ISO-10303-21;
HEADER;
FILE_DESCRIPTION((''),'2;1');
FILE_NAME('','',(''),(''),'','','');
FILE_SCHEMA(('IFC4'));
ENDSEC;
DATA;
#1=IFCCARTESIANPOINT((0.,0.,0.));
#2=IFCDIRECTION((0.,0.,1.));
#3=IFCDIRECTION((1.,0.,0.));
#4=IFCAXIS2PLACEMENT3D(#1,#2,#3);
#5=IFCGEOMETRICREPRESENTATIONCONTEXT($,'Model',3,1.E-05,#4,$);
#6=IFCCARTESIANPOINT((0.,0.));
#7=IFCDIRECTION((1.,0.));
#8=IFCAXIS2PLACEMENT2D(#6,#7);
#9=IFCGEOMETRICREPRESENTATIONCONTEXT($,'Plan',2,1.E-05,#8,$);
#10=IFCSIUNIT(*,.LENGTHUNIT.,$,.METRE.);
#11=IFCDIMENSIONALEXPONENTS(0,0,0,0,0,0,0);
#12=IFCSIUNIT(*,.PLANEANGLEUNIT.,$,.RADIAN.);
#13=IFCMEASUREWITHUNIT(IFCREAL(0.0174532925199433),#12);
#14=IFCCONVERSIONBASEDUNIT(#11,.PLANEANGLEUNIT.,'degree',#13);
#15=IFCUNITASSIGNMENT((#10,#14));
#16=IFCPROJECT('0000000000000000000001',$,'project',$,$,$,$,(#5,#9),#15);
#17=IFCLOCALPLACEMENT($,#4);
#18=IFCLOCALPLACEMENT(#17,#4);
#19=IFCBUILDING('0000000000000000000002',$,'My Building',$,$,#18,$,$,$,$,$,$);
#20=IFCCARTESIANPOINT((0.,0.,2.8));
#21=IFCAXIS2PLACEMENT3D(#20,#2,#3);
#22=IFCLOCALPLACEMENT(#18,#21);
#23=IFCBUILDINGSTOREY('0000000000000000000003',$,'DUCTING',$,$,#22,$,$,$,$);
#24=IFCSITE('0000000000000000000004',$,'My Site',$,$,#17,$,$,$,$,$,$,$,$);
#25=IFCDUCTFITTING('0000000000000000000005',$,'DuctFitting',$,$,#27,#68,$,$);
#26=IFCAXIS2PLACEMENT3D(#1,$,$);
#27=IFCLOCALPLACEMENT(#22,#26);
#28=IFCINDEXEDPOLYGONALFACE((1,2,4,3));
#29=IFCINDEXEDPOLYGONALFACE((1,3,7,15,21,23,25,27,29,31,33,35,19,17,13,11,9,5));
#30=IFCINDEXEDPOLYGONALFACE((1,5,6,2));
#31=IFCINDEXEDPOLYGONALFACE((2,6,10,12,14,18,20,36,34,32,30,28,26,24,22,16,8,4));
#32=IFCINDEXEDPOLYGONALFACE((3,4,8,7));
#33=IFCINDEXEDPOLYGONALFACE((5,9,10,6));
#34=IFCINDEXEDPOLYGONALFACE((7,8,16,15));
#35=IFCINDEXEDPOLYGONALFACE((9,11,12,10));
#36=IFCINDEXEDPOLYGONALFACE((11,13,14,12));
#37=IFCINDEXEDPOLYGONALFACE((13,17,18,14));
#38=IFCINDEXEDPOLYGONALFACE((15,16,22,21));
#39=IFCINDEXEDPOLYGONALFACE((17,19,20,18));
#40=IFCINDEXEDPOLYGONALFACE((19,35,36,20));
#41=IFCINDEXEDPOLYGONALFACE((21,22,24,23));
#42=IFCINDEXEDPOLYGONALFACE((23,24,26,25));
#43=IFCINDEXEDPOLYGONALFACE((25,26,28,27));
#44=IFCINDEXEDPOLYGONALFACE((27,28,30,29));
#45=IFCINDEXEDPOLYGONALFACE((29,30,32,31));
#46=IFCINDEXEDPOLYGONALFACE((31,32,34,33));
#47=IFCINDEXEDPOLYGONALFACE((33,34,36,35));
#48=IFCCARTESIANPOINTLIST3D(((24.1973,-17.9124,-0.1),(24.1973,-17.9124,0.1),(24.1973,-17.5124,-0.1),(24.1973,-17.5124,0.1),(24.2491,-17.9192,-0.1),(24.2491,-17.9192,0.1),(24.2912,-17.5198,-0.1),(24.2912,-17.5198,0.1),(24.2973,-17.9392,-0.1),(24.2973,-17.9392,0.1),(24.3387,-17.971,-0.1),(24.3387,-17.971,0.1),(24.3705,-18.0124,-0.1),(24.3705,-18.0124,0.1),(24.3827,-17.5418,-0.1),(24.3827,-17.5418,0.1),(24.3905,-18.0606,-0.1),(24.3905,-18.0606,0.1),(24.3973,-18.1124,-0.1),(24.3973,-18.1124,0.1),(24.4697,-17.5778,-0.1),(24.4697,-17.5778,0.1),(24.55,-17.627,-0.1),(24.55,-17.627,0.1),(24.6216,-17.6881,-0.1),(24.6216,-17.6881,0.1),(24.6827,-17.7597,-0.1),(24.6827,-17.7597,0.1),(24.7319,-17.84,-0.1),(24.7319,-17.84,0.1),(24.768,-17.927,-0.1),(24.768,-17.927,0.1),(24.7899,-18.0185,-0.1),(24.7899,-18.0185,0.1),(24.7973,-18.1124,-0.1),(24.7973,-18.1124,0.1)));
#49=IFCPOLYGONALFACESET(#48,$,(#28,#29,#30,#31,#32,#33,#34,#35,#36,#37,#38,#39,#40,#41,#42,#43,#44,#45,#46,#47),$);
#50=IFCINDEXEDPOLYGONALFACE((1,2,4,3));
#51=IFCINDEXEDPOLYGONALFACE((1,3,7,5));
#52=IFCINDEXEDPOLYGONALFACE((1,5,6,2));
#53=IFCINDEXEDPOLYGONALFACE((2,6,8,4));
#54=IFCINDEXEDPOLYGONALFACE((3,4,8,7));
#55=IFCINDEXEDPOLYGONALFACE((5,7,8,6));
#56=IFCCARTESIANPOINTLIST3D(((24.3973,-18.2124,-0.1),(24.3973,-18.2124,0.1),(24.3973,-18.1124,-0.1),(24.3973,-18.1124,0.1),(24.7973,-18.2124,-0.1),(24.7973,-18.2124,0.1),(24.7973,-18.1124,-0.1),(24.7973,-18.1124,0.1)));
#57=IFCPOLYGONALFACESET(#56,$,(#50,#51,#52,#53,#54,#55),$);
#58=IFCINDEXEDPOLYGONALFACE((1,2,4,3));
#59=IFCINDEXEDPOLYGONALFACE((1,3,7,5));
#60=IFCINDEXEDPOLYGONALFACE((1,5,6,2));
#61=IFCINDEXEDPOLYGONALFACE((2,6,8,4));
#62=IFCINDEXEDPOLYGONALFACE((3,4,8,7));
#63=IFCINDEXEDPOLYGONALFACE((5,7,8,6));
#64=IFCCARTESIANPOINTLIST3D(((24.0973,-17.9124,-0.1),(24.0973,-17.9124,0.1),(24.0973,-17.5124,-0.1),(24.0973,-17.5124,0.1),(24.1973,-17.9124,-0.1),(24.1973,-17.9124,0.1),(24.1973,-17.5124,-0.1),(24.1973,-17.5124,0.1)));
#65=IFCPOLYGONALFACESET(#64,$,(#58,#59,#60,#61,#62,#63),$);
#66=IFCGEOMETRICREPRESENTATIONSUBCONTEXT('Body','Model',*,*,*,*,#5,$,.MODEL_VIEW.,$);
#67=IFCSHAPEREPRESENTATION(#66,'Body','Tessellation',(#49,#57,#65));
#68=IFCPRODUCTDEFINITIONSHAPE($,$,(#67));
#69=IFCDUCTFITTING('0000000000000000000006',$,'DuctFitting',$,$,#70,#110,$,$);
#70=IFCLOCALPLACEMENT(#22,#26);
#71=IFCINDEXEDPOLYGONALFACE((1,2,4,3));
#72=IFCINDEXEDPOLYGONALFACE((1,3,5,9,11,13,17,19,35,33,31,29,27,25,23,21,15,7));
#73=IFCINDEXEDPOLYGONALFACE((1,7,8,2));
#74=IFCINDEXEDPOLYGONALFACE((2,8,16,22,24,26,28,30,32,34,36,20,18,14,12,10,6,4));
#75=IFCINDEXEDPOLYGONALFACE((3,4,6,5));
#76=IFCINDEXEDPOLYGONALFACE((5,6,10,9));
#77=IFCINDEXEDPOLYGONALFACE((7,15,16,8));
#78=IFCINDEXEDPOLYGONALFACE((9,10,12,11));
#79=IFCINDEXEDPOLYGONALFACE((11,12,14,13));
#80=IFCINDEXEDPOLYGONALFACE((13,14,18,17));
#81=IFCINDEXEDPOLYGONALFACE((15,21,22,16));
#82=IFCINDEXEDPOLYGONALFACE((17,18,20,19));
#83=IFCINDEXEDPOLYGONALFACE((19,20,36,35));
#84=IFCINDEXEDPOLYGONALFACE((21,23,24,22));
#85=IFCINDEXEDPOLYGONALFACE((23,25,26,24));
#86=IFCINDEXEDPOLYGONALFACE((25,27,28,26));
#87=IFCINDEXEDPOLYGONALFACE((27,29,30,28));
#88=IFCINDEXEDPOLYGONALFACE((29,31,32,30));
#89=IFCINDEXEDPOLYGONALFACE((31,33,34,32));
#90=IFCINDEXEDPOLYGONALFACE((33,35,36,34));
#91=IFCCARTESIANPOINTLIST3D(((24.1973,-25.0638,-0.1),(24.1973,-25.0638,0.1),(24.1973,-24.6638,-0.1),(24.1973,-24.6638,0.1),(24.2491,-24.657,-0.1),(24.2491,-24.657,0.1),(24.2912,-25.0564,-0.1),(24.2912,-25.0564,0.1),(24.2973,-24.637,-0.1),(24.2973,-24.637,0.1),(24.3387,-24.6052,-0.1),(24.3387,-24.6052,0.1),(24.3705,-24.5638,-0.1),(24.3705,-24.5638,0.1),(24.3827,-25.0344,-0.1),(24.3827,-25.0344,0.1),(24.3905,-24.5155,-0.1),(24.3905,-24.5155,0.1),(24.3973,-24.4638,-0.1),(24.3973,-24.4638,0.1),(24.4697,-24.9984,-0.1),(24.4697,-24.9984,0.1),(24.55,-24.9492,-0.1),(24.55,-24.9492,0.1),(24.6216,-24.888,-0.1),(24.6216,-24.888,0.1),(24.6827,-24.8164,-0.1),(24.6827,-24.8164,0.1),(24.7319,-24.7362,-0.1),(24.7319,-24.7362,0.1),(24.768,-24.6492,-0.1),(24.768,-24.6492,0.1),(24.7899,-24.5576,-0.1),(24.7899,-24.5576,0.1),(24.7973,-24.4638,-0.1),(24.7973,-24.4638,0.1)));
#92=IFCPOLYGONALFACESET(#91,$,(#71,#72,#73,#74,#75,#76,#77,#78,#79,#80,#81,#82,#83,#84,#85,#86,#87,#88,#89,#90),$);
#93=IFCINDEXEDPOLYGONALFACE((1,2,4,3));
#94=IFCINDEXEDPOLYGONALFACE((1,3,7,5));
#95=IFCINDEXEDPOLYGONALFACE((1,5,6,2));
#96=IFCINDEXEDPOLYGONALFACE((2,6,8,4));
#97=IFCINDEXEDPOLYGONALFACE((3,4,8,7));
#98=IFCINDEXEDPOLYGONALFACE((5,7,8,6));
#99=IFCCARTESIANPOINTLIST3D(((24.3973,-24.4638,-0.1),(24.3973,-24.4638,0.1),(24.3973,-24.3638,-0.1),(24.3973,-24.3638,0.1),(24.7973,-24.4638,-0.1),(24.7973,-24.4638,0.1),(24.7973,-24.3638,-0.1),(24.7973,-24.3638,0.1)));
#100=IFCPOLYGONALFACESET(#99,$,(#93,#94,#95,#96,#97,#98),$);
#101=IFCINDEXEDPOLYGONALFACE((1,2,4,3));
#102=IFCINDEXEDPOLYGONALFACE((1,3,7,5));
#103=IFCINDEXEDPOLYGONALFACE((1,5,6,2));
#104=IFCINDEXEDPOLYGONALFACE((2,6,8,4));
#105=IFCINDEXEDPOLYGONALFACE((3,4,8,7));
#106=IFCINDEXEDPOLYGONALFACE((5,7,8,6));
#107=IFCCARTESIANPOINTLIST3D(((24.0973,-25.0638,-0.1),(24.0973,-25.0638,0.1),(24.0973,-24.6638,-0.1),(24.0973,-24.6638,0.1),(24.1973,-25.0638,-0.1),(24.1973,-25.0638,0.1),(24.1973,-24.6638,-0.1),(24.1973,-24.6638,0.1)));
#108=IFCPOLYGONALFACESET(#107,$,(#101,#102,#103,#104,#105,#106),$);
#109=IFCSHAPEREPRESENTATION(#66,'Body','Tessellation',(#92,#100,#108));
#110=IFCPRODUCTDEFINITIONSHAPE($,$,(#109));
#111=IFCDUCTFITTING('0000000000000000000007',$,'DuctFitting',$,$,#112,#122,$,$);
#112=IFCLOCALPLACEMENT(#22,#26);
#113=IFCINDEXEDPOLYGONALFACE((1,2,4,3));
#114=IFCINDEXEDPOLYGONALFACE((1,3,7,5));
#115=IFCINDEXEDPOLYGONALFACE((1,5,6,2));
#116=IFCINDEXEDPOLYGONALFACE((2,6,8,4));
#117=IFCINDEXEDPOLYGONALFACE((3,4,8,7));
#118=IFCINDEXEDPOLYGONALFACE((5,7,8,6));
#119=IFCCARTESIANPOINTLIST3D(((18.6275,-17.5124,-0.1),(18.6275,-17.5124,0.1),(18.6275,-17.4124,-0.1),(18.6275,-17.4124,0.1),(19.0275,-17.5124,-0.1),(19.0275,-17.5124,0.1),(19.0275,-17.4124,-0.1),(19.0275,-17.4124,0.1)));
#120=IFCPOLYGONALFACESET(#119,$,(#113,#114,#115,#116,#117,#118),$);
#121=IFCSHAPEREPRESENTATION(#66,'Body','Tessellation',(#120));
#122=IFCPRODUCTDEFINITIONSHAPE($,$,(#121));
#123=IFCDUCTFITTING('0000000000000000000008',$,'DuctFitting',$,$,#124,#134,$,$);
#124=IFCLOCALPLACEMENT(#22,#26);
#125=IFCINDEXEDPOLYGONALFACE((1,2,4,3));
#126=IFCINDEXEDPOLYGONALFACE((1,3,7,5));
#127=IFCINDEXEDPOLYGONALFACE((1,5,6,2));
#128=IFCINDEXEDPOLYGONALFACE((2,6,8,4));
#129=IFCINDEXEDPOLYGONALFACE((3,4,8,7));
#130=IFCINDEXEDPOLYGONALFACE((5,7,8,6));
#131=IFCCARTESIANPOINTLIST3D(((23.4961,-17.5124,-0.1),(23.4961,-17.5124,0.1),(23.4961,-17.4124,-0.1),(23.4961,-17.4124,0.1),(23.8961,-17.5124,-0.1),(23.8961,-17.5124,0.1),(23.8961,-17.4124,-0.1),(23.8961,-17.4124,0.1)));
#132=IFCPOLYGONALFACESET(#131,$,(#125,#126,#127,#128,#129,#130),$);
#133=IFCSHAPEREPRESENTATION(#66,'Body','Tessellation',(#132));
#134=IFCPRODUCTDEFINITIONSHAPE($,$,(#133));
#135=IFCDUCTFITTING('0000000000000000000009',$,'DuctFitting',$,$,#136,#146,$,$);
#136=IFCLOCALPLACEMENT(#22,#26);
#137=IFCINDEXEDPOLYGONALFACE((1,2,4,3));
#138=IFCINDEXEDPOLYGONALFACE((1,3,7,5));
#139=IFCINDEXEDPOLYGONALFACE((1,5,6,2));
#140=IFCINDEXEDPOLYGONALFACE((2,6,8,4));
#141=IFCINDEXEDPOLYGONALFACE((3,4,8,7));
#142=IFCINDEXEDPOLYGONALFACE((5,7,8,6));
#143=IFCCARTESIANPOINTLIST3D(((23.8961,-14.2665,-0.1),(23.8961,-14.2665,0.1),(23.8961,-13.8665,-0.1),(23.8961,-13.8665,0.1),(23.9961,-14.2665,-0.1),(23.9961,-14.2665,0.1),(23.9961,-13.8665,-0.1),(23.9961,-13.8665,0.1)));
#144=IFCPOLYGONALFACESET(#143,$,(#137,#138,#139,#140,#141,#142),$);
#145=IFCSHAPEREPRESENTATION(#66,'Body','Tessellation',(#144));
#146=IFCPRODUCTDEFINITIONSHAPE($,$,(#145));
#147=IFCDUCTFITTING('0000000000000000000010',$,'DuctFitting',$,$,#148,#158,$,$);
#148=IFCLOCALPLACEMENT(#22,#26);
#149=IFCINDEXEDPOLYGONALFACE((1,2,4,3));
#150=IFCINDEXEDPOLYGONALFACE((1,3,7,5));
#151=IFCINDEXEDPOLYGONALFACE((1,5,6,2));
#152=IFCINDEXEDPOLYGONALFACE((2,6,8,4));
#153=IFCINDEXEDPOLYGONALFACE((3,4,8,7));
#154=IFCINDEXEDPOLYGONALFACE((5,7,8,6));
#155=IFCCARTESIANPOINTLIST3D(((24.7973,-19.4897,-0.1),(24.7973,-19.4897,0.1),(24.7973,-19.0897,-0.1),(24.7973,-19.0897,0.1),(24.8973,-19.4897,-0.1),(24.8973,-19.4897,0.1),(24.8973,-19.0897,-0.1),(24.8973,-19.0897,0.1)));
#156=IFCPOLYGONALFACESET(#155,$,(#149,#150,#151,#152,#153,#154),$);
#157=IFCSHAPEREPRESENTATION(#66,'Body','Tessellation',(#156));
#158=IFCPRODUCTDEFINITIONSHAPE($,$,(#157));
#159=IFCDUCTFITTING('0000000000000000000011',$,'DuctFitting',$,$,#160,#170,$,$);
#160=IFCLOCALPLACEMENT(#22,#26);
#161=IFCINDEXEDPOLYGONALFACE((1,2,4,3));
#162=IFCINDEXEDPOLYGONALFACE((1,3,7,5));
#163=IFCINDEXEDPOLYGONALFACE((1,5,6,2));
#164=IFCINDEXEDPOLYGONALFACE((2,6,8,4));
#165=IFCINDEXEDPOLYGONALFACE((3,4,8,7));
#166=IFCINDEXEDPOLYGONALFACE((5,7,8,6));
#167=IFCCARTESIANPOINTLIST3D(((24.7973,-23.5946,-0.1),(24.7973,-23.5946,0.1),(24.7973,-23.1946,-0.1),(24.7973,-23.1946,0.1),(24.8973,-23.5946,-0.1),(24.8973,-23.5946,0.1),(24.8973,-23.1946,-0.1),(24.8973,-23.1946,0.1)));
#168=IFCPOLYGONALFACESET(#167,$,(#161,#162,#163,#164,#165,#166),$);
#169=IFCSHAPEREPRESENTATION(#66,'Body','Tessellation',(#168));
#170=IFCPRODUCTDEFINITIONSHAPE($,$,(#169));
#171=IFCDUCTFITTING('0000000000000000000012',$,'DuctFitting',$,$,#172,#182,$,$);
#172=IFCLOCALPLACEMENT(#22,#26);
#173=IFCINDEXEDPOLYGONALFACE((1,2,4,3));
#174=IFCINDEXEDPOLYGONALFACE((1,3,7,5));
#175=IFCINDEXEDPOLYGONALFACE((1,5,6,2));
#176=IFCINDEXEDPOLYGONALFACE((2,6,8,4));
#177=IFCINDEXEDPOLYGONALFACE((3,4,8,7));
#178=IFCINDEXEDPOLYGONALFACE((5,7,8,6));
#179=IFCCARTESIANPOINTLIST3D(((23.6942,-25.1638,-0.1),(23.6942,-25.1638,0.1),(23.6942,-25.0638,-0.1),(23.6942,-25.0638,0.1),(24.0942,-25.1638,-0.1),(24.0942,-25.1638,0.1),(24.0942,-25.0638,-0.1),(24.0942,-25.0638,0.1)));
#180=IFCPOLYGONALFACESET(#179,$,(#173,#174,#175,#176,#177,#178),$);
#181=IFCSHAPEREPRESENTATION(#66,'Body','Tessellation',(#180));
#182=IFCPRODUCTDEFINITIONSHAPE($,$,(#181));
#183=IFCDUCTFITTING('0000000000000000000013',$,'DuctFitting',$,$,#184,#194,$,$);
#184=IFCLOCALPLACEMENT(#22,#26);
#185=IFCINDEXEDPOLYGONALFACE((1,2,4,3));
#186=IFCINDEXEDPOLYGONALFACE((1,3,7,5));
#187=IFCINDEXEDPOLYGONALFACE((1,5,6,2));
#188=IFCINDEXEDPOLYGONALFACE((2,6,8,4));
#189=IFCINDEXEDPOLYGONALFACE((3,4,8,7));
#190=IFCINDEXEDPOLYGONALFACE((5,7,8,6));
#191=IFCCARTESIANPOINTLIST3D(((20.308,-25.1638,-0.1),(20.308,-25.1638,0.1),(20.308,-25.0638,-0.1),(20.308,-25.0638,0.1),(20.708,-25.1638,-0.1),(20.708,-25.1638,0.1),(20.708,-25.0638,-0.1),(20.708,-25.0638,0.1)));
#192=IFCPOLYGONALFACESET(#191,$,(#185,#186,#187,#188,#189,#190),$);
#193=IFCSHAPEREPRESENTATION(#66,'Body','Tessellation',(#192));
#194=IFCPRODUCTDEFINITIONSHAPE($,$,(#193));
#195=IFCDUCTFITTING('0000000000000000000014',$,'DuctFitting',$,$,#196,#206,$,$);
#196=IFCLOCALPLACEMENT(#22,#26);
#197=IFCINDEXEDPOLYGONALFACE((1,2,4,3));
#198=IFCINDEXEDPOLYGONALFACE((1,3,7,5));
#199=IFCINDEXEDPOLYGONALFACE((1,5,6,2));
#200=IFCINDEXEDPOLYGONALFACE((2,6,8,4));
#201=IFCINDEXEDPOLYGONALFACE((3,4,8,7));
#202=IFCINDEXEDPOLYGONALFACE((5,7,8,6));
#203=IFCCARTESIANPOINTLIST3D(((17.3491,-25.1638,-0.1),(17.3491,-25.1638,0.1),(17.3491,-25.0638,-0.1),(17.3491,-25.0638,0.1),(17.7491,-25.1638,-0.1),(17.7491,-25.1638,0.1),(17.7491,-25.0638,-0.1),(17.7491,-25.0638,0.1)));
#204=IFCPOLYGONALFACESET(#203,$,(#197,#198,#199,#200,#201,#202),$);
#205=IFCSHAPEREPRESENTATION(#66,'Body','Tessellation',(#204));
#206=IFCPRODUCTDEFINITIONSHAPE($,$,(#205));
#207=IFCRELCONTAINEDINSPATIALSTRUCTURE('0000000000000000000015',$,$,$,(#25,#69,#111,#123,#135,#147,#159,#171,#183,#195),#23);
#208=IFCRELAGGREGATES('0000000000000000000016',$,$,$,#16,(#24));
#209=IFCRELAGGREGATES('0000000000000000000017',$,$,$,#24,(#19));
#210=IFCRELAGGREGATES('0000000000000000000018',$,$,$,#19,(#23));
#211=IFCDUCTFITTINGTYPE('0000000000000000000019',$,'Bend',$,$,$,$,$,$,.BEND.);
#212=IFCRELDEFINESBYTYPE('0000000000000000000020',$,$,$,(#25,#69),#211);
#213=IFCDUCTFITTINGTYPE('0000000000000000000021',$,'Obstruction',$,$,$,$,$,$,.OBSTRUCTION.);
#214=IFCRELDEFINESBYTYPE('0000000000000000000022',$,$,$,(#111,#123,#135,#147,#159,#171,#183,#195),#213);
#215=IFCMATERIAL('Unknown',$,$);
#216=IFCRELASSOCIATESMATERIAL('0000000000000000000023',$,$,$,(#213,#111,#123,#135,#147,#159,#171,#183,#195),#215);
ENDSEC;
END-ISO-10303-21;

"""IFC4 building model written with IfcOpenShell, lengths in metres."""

from ifc_helpers import new_model, entity, si_unit, converted_unit, frame, origin_with_axes, origin_2d_with_axis, place, context, subcontext, project, spatial, line, arc, indexed_curve, rectangle, outline, extrude, source, transform, mapped, material, material_profile, profile_set, profile_usage, type_object, type_shapes, element, save


model = new_model("IFC4")

# Units and contexts
model_context = context("Model", 3, precision=1e-05, world=origin_with_axes())
plan_context = context("Plan", 2, precision=1e-05, world=origin_2d_with_axis())
body_context = subcontext(model_context, "Body", "Model", "MODEL_VIEW")
ifc_project = project(units=[si_unit("LENGTHUNIT", "METRE"), converted_unit("PLANEANGLEUNIT", "degree", entity("IfcReal", 0.0174532925199433), si_unit("PLANEANGLEUNIT", "RADIAN"), dimensions=[0, 0, 0, 0, 0, 0, 0])], contexts=[model_context, plan_context])

# Site, building, storey
site_placement = place(None, origin_with_axes())
site = spatial("IfcSite", under=ifc_project, at=site_placement, Name="My Site")
building_placement = place(site_placement, origin_with_axes())
building = spatial("IfcBuilding", under=site, at=building_placement, Name="My Building")
storey_placement = place(building_placement, frame((0.0, 0.0, 2.8), z_axis=(0.0, 0.0, 1.0), x_axis=(1.0, 0.0, 0.0)))
storey = spatial("IfcBuildingStorey", under=building, at=storey_placement, Name="DUCTING")

# Shared definitions
ifc_material = material(Name="Unknown")

# Duct fittings
duct_fitting_type_1 = type_object("IfcDuctFittingType", Name="Bend", PredefinedType="BEND")
shared_shape = source(origin_with_axes(), body_context, "Body", "SweptSolid", [
    extrude(outline(indexed_curve([(0.2, 0.0), (0.2586, -0.1414), (0.4, -0.2), (0.4, -0.6), (-0.0243, -0.4243), (-0.2, 0.0)], segments=[arc(1, 2, 3), line(3, 4), arc(4, 5, 6), line(6, 1)])), frame((0.0, -0.1, -0.1), z_axis=(0.0, -1.0, 0.0), x_axis=(1.0, 0.0, 0.0)), (0.0, 0.0, -1.0), 0.2),
    extrude(rectangle(XDim=0.4, YDim=0.2), origin_with_axes(), (0.0, 0.0, -1.0), 0.1),
    extrude(rectangle(XDim=0.4, YDim=0.2), frame((0.4, 0.0, -0.5), z_axis=(1.0, 0.0, 0.0), x_axis=(0.0, 0.0, 1.0)), (0.0, 0.0, 1.0), 0.1),
])
type_shapes(duct_fitting_type_1, [shared_shape])
for number, where, z_axis, x_axis, name in (
    (1, (24.5973, -18.2124, 0.0), (0.0, -1.0, 0.0), (-1.0, 0.0, 0.0), "DuctFitting"),
    (2, (24.5973, -24.3638, 0.0), (0.0, 1.0, 0.0), (-1.0, 0.0, 0.0), "DuctFitting"),
):
    element("IfcDuctFitting", number, at=place(storey_placement, frame(where, z_axis=z_axis, x_axis=x_axis)), inside=storey, type_object=duct_fitting_type_1, Name=name, context=body_context, shape_type="MappedRepresentation", body=[
        mapped(shared_shape, transform((0.0, 0.0, 0.0), x_axis=(1.0, 0.0, 0.0), y_axis=(0.0, 1.0, 0.0), z_axis=(0.0, 0.0, 1.0), scale=1.0)),
    ])
ifc_material_profile_1 = material_profile(ifc_material, rectangle(XDim=0.4, YDim=0.2))
ifc_profile_set_1 = profile_set([ifc_material_profile_1])
ifc_profile_usage_1 = profile_usage(ifc_profile_set_1, cardinal=5)
duct_fitting_type_2 = type_object("IfcDuctFittingType", Name="Obstruction", PredefinedType="OBSTRUCTION", material=ifc_profile_set_1)
duct_fitting_1_placement = place(storey_placement, frame((18.8275, -17.5124, 0.0), z_axis=(0.0, 1.0, 0.0), x_axis=(-1.0, 0.0, 0.0)))
element("IfcDuctFitting", 3, at=duct_fitting_1_placement, inside=storey, type_object=duct_fitting_type_2, material=ifc_profile_usage_1, Name="DuctFitting", context=body_context, shape_type="SweptSolid", body=[
    extrude(rectangle(XDim=0.4, YDim=0.2), origin_with_axes(), (0.0, 0.0, 1.0), 0.1),
])
ifc_profile_usage_2 = profile_usage(ifc_profile_set_1, cardinal=5)
duct_fitting_2_placement = place(storey_placement, frame((23.6961, -17.5124, 0.0), z_axis=(0.0, 1.0, 0.0), x_axis=(-1.0, 0.0, 0.0)))
element("IfcDuctFitting", 4, at=duct_fitting_2_placement, inside=storey, type_object=duct_fitting_type_2, material=ifc_profile_usage_2, Name="DuctFitting", context=body_context, shape_type="SweptSolid", body=[
    extrude(rectangle(XDim=0.4, YDim=0.2), origin_with_axes(), (0.0, 0.0, 1.0), 0.1),
])
ifc_profile_usage_3 = profile_usage(ifc_profile_set_1, cardinal=5)
duct_fitting_3_placement = place(storey_placement, frame((23.8961, -14.0665, 0.0), z_axis=(1.0, 0.0, 0.0), x_axis=(0.0, 1.0, 0.0)))
element("IfcDuctFitting", 5, at=duct_fitting_3_placement, inside=storey, type_object=duct_fitting_type_2, material=ifc_profile_usage_3, Name="DuctFitting", context=body_context, shape_type="SweptSolid", body=[
    extrude(rectangle(XDim=0.4, YDim=0.2), origin_with_axes(), (0.0, 0.0, 1.0), 0.1),
])
ifc_profile_usage_4 = profile_usage(ifc_profile_set_1, cardinal=5)
duct_fitting_4_placement = place(storey_placement, frame((24.7973, -19.2897, 0.0), z_axis=(1.0, 0.0, 0.0), x_axis=(0.0, 1.0, 0.0)))
element("IfcDuctFitting", 6, at=duct_fitting_4_placement, inside=storey, type_object=duct_fitting_type_2, material=ifc_profile_usage_4, Name="DuctFitting", context=body_context, shape_type="SweptSolid", body=[
    extrude(rectangle(XDim=0.4, YDim=0.2), origin_with_axes(), (0.0, 0.0, 1.0), 0.1),
])
ifc_profile_usage_5 = profile_usage(ifc_profile_set_1, cardinal=5)
duct_fitting_5_placement = place(storey_placement, frame((24.7973, -23.3946, 0.0), z_axis=(1.0, 0.0, 0.0), x_axis=(0.0, 1.0, 0.0)))
element("IfcDuctFitting", 7, at=duct_fitting_5_placement, inside=storey, type_object=duct_fitting_type_2, material=ifc_profile_usage_5, Name="DuctFitting", context=body_context, shape_type="SweptSolid", body=[
    extrude(rectangle(XDim=0.4, YDim=0.2), origin_with_axes(), (0.0, 0.0, 1.0), 0.1),
])
ifc_profile_usage_6 = profile_usage(ifc_profile_set_1, cardinal=5)
duct_fitting_6_placement = place(storey_placement, frame((23.8942, -25.0638, 0.0), z_axis=(0.0, -1.0, 0.0), x_axis=(1.0, 0.0, 0.0)))
element("IfcDuctFitting", 8, at=duct_fitting_6_placement, inside=storey, type_object=duct_fitting_type_2, material=ifc_profile_usage_6, Name="DuctFitting", context=body_context, shape_type="SweptSolid", body=[
    extrude(rectangle(XDim=0.4, YDim=0.2), origin_with_axes(), (0.0, 0.0, 1.0), 0.1),
])
ifc_profile_usage_7 = profile_usage(ifc_profile_set_1, cardinal=5)
duct_fitting_7_placement = place(storey_placement, frame((20.508, -25.0638, 0.0), z_axis=(0.0, -1.0, 0.0), x_axis=(1.0, 0.0, 0.0)))
element("IfcDuctFitting", 9, at=duct_fitting_7_placement, inside=storey, type_object=duct_fitting_type_2, material=ifc_profile_usage_7, Name="DuctFitting", context=body_context, shape_type="SweptSolid", body=[
    extrude(rectangle(XDim=0.4, YDim=0.2), origin_with_axes(), (0.0, 0.0, 1.0), 0.1),
])
ifc_profile_usage_8 = profile_usage(ifc_profile_set_1, cardinal=5)
duct_fitting_8_placement = place(storey_placement, frame((17.5491, -25.0638, 0.0), z_axis=(0.0, -1.0, 0.0), x_axis=(1.0, 0.0, 0.0)))
element("IfcDuctFitting", 10, at=duct_fitting_8_placement, inside=storey, type_object=duct_fitting_type_2, material=ifc_profile_usage_8, Name="DuctFitting", context=body_context, shape_type="SweptSolid", body=[
    extrude(rectangle(XDim=0.4, YDim=0.2), origin_with_axes(), (0.0, 0.0, 1.0), 0.1),
])

save(model, "model.ifc")
